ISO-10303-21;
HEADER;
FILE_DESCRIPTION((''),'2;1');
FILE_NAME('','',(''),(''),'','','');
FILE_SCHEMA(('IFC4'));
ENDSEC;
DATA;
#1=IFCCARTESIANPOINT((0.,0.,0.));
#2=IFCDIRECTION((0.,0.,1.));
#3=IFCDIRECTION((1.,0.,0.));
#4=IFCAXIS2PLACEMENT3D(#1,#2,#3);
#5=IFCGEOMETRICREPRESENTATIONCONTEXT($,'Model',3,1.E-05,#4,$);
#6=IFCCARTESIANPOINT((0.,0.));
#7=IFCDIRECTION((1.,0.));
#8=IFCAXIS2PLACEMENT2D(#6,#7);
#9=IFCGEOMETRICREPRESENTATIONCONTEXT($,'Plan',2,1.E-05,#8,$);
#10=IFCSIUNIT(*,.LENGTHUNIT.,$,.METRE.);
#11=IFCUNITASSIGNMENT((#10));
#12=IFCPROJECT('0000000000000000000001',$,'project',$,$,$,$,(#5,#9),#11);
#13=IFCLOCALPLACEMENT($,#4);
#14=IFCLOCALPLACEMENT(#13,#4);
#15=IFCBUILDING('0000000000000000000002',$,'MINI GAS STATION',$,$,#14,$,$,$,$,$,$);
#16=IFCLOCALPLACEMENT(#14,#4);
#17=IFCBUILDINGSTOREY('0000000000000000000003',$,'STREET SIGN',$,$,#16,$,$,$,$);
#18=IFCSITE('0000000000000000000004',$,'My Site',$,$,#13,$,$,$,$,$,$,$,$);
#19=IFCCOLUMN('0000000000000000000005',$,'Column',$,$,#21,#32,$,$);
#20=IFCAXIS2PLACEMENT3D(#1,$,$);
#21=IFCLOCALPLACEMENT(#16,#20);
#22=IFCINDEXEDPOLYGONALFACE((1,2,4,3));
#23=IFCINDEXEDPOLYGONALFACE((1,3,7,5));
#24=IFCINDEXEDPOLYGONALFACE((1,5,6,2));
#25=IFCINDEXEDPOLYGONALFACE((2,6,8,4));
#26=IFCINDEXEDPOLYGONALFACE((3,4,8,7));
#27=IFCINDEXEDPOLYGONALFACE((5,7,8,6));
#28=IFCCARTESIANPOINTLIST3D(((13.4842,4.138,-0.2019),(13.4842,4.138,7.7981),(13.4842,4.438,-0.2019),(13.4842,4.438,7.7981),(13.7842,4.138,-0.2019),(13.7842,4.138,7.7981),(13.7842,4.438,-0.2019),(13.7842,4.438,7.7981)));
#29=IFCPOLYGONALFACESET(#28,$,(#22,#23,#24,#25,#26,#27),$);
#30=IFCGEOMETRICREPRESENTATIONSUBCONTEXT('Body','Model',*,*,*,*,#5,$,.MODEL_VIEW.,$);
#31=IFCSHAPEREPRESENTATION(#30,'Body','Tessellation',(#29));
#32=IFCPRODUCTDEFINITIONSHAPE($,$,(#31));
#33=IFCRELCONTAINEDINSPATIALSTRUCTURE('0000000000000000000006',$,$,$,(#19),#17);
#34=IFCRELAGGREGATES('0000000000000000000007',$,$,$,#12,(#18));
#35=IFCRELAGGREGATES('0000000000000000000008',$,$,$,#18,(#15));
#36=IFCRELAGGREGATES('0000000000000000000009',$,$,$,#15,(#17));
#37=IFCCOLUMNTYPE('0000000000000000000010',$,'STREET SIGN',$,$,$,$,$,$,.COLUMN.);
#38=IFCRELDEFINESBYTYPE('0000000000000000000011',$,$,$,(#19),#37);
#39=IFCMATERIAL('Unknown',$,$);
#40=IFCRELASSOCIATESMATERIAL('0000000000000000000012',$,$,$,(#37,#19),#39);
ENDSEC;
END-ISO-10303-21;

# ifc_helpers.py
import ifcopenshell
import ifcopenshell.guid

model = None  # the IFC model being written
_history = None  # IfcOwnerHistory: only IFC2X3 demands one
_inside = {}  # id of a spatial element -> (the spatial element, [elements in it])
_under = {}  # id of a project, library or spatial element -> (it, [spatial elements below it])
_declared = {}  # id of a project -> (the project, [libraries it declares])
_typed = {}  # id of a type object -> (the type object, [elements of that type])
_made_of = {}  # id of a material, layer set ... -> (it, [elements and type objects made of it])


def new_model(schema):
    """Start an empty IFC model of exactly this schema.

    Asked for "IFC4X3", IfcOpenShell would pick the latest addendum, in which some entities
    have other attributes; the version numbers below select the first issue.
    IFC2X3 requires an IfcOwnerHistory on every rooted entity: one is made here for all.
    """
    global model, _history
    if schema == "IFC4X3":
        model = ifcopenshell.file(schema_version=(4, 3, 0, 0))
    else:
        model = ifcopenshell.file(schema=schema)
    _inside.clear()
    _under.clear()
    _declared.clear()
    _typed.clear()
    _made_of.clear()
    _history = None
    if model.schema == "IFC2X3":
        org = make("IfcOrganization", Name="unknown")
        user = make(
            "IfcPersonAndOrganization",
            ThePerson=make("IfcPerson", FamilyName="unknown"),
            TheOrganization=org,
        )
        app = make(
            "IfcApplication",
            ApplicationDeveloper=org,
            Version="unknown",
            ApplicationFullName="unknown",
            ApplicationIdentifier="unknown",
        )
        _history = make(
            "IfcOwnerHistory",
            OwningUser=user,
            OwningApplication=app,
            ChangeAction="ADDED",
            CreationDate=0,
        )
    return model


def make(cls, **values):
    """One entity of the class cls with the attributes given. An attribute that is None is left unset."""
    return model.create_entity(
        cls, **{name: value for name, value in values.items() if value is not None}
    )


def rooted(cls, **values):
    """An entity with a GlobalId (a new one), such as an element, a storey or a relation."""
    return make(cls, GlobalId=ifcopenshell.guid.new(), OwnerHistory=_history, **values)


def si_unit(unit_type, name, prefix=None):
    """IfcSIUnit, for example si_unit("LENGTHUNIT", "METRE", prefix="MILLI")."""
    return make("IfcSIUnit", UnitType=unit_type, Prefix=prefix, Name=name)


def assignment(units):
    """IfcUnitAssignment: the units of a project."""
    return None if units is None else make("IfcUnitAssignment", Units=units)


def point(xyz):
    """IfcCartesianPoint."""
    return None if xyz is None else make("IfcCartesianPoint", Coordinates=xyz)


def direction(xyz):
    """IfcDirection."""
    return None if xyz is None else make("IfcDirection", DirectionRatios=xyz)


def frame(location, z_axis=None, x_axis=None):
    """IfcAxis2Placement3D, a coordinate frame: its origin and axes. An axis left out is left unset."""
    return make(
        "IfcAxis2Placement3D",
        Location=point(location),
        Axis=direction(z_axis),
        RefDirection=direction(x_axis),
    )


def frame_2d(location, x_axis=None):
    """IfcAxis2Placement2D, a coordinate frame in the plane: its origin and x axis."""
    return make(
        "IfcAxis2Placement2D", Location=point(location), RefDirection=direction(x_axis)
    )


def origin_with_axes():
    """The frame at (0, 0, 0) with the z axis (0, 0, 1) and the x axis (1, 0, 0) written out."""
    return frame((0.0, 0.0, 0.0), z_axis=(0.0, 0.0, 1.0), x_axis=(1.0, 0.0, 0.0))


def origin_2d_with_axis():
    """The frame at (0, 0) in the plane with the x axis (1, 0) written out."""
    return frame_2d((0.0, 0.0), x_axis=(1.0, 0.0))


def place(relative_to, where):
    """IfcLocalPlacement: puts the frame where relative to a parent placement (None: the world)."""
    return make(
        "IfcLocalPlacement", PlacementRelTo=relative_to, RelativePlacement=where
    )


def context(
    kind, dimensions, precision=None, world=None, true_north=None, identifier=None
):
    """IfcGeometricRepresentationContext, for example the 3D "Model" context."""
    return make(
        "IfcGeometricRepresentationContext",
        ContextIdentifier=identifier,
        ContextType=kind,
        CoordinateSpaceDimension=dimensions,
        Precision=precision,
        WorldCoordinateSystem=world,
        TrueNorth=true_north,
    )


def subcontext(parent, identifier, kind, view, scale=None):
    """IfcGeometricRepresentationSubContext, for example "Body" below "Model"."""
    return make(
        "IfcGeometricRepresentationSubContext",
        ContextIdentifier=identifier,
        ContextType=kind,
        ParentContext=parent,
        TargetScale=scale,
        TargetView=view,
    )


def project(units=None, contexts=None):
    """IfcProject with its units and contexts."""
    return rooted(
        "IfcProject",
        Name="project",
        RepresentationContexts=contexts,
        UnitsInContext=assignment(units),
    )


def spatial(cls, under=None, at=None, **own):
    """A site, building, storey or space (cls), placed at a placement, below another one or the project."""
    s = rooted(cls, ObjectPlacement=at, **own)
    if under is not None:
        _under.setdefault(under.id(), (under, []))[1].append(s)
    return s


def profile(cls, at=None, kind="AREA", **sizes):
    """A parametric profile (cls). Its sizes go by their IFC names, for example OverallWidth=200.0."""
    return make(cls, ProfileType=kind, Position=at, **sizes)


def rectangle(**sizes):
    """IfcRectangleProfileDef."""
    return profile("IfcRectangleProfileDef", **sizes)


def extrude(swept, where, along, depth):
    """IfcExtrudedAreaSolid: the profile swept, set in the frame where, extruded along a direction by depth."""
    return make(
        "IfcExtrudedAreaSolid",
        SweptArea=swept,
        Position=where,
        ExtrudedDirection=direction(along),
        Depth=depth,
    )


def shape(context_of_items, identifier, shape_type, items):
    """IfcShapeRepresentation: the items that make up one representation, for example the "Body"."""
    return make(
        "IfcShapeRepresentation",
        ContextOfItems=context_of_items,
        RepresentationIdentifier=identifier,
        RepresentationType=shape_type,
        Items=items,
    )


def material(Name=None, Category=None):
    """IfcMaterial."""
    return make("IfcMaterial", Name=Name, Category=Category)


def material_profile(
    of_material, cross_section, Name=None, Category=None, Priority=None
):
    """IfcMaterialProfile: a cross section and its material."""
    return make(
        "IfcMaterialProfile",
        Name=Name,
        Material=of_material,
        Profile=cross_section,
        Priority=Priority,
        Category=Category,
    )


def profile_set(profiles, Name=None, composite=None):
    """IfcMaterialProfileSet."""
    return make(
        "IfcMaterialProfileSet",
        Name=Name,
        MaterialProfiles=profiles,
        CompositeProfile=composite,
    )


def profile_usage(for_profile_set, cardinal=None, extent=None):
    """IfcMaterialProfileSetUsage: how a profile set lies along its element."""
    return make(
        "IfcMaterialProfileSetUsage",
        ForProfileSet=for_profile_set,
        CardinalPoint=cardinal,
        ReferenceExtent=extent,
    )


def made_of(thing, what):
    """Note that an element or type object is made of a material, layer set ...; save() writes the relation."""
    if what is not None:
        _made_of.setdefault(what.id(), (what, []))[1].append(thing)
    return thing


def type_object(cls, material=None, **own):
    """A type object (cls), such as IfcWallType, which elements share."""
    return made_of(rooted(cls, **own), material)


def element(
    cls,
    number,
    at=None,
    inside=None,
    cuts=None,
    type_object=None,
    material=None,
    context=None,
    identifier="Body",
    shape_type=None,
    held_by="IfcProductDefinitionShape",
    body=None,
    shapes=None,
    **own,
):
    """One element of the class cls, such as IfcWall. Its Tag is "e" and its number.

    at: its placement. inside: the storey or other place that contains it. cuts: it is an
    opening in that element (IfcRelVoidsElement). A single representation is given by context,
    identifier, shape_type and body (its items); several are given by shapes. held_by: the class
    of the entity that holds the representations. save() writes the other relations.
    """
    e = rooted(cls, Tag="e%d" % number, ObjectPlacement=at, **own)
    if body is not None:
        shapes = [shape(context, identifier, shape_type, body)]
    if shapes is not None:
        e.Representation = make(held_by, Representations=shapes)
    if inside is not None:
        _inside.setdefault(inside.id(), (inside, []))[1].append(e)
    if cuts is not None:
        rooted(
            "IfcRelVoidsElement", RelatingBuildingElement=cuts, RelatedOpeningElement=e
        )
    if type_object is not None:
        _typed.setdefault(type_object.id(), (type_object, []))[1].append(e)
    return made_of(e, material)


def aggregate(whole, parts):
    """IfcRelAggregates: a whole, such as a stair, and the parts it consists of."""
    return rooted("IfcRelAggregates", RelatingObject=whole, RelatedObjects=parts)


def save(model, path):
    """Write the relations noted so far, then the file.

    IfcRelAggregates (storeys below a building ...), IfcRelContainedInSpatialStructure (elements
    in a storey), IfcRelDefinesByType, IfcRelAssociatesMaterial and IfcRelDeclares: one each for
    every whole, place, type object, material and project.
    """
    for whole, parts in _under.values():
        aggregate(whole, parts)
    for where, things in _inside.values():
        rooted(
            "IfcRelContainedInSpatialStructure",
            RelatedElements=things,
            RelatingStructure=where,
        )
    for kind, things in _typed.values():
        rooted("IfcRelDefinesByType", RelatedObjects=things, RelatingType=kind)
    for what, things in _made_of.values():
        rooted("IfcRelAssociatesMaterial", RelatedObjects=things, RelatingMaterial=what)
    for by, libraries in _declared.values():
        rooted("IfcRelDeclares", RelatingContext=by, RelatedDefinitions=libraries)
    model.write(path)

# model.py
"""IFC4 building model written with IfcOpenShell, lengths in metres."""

from ifc_helpers import new_model, si_unit, frame, origin_with_axes, origin_2d_with_axis, place, context, subcontext, project, spatial, rectangle, extrude, material, material_profile, profile_set, profile_usage, type_object, element, save


model = new_model("IFC4")

# Units and contexts
model_context = context("Model", 3, precision=1e-05, world=origin_with_axes())
plan_context = context("Plan", 2, precision=1e-05, world=origin_2d_with_axis())
body_context = subcontext(model_context, "Body", "Model", "MODEL_VIEW")
ifc_project = project(units=[si_unit("LENGTHUNIT", "METRE")], contexts=[model_context, plan_context])

# Site, building, storey
site_placement = place(None, origin_with_axes())
site = spatial("IfcSite", under=ifc_project, at=site_placement, Name="My Site")
building_placement = place(site_placement, origin_with_axes())
building = spatial("IfcBuilding", under=site, at=building_placement, Name="MINI GAS STATION")
storey_placement = place(building_placement, origin_with_axes())
storey = spatial("IfcBuildingStorey", under=building, at=storey_placement, Name="STREET SIGN")

# Column
ifc_material = material(Name="Unknown")
ifc_material_profile = material_profile(ifc_material, rectangle(XDim=0.3, YDim=0.3))
ifc_profile_set = profile_set([ifc_material_profile])
ifc_profile_usage = profile_usage(ifc_profile_set, cardinal=5)
column_type = type_object("IfcColumnType", Name="STREET SIGN", PredefinedType="COLUMN", material=ifc_profile_set)
column_placement = place(storey_placement, frame((13.6342, 4.288, -0.2019), z_axis=(0.0, 0.0, 1.0), x_axis=(1.0, 0.0, 0.0)))
element("IfcColumn", 1, at=column_placement, inside=storey, type_object=column_type, material=ifc_profile_usage, Name="Column", context=body_context, shape_type="SweptSolid", body=[
    extrude(rectangle(XDim=0.3, YDim=0.3), origin_with_axes(), (0.0, 0.0, 1.0), 8.0),
])

save(model, "model.ifc")
